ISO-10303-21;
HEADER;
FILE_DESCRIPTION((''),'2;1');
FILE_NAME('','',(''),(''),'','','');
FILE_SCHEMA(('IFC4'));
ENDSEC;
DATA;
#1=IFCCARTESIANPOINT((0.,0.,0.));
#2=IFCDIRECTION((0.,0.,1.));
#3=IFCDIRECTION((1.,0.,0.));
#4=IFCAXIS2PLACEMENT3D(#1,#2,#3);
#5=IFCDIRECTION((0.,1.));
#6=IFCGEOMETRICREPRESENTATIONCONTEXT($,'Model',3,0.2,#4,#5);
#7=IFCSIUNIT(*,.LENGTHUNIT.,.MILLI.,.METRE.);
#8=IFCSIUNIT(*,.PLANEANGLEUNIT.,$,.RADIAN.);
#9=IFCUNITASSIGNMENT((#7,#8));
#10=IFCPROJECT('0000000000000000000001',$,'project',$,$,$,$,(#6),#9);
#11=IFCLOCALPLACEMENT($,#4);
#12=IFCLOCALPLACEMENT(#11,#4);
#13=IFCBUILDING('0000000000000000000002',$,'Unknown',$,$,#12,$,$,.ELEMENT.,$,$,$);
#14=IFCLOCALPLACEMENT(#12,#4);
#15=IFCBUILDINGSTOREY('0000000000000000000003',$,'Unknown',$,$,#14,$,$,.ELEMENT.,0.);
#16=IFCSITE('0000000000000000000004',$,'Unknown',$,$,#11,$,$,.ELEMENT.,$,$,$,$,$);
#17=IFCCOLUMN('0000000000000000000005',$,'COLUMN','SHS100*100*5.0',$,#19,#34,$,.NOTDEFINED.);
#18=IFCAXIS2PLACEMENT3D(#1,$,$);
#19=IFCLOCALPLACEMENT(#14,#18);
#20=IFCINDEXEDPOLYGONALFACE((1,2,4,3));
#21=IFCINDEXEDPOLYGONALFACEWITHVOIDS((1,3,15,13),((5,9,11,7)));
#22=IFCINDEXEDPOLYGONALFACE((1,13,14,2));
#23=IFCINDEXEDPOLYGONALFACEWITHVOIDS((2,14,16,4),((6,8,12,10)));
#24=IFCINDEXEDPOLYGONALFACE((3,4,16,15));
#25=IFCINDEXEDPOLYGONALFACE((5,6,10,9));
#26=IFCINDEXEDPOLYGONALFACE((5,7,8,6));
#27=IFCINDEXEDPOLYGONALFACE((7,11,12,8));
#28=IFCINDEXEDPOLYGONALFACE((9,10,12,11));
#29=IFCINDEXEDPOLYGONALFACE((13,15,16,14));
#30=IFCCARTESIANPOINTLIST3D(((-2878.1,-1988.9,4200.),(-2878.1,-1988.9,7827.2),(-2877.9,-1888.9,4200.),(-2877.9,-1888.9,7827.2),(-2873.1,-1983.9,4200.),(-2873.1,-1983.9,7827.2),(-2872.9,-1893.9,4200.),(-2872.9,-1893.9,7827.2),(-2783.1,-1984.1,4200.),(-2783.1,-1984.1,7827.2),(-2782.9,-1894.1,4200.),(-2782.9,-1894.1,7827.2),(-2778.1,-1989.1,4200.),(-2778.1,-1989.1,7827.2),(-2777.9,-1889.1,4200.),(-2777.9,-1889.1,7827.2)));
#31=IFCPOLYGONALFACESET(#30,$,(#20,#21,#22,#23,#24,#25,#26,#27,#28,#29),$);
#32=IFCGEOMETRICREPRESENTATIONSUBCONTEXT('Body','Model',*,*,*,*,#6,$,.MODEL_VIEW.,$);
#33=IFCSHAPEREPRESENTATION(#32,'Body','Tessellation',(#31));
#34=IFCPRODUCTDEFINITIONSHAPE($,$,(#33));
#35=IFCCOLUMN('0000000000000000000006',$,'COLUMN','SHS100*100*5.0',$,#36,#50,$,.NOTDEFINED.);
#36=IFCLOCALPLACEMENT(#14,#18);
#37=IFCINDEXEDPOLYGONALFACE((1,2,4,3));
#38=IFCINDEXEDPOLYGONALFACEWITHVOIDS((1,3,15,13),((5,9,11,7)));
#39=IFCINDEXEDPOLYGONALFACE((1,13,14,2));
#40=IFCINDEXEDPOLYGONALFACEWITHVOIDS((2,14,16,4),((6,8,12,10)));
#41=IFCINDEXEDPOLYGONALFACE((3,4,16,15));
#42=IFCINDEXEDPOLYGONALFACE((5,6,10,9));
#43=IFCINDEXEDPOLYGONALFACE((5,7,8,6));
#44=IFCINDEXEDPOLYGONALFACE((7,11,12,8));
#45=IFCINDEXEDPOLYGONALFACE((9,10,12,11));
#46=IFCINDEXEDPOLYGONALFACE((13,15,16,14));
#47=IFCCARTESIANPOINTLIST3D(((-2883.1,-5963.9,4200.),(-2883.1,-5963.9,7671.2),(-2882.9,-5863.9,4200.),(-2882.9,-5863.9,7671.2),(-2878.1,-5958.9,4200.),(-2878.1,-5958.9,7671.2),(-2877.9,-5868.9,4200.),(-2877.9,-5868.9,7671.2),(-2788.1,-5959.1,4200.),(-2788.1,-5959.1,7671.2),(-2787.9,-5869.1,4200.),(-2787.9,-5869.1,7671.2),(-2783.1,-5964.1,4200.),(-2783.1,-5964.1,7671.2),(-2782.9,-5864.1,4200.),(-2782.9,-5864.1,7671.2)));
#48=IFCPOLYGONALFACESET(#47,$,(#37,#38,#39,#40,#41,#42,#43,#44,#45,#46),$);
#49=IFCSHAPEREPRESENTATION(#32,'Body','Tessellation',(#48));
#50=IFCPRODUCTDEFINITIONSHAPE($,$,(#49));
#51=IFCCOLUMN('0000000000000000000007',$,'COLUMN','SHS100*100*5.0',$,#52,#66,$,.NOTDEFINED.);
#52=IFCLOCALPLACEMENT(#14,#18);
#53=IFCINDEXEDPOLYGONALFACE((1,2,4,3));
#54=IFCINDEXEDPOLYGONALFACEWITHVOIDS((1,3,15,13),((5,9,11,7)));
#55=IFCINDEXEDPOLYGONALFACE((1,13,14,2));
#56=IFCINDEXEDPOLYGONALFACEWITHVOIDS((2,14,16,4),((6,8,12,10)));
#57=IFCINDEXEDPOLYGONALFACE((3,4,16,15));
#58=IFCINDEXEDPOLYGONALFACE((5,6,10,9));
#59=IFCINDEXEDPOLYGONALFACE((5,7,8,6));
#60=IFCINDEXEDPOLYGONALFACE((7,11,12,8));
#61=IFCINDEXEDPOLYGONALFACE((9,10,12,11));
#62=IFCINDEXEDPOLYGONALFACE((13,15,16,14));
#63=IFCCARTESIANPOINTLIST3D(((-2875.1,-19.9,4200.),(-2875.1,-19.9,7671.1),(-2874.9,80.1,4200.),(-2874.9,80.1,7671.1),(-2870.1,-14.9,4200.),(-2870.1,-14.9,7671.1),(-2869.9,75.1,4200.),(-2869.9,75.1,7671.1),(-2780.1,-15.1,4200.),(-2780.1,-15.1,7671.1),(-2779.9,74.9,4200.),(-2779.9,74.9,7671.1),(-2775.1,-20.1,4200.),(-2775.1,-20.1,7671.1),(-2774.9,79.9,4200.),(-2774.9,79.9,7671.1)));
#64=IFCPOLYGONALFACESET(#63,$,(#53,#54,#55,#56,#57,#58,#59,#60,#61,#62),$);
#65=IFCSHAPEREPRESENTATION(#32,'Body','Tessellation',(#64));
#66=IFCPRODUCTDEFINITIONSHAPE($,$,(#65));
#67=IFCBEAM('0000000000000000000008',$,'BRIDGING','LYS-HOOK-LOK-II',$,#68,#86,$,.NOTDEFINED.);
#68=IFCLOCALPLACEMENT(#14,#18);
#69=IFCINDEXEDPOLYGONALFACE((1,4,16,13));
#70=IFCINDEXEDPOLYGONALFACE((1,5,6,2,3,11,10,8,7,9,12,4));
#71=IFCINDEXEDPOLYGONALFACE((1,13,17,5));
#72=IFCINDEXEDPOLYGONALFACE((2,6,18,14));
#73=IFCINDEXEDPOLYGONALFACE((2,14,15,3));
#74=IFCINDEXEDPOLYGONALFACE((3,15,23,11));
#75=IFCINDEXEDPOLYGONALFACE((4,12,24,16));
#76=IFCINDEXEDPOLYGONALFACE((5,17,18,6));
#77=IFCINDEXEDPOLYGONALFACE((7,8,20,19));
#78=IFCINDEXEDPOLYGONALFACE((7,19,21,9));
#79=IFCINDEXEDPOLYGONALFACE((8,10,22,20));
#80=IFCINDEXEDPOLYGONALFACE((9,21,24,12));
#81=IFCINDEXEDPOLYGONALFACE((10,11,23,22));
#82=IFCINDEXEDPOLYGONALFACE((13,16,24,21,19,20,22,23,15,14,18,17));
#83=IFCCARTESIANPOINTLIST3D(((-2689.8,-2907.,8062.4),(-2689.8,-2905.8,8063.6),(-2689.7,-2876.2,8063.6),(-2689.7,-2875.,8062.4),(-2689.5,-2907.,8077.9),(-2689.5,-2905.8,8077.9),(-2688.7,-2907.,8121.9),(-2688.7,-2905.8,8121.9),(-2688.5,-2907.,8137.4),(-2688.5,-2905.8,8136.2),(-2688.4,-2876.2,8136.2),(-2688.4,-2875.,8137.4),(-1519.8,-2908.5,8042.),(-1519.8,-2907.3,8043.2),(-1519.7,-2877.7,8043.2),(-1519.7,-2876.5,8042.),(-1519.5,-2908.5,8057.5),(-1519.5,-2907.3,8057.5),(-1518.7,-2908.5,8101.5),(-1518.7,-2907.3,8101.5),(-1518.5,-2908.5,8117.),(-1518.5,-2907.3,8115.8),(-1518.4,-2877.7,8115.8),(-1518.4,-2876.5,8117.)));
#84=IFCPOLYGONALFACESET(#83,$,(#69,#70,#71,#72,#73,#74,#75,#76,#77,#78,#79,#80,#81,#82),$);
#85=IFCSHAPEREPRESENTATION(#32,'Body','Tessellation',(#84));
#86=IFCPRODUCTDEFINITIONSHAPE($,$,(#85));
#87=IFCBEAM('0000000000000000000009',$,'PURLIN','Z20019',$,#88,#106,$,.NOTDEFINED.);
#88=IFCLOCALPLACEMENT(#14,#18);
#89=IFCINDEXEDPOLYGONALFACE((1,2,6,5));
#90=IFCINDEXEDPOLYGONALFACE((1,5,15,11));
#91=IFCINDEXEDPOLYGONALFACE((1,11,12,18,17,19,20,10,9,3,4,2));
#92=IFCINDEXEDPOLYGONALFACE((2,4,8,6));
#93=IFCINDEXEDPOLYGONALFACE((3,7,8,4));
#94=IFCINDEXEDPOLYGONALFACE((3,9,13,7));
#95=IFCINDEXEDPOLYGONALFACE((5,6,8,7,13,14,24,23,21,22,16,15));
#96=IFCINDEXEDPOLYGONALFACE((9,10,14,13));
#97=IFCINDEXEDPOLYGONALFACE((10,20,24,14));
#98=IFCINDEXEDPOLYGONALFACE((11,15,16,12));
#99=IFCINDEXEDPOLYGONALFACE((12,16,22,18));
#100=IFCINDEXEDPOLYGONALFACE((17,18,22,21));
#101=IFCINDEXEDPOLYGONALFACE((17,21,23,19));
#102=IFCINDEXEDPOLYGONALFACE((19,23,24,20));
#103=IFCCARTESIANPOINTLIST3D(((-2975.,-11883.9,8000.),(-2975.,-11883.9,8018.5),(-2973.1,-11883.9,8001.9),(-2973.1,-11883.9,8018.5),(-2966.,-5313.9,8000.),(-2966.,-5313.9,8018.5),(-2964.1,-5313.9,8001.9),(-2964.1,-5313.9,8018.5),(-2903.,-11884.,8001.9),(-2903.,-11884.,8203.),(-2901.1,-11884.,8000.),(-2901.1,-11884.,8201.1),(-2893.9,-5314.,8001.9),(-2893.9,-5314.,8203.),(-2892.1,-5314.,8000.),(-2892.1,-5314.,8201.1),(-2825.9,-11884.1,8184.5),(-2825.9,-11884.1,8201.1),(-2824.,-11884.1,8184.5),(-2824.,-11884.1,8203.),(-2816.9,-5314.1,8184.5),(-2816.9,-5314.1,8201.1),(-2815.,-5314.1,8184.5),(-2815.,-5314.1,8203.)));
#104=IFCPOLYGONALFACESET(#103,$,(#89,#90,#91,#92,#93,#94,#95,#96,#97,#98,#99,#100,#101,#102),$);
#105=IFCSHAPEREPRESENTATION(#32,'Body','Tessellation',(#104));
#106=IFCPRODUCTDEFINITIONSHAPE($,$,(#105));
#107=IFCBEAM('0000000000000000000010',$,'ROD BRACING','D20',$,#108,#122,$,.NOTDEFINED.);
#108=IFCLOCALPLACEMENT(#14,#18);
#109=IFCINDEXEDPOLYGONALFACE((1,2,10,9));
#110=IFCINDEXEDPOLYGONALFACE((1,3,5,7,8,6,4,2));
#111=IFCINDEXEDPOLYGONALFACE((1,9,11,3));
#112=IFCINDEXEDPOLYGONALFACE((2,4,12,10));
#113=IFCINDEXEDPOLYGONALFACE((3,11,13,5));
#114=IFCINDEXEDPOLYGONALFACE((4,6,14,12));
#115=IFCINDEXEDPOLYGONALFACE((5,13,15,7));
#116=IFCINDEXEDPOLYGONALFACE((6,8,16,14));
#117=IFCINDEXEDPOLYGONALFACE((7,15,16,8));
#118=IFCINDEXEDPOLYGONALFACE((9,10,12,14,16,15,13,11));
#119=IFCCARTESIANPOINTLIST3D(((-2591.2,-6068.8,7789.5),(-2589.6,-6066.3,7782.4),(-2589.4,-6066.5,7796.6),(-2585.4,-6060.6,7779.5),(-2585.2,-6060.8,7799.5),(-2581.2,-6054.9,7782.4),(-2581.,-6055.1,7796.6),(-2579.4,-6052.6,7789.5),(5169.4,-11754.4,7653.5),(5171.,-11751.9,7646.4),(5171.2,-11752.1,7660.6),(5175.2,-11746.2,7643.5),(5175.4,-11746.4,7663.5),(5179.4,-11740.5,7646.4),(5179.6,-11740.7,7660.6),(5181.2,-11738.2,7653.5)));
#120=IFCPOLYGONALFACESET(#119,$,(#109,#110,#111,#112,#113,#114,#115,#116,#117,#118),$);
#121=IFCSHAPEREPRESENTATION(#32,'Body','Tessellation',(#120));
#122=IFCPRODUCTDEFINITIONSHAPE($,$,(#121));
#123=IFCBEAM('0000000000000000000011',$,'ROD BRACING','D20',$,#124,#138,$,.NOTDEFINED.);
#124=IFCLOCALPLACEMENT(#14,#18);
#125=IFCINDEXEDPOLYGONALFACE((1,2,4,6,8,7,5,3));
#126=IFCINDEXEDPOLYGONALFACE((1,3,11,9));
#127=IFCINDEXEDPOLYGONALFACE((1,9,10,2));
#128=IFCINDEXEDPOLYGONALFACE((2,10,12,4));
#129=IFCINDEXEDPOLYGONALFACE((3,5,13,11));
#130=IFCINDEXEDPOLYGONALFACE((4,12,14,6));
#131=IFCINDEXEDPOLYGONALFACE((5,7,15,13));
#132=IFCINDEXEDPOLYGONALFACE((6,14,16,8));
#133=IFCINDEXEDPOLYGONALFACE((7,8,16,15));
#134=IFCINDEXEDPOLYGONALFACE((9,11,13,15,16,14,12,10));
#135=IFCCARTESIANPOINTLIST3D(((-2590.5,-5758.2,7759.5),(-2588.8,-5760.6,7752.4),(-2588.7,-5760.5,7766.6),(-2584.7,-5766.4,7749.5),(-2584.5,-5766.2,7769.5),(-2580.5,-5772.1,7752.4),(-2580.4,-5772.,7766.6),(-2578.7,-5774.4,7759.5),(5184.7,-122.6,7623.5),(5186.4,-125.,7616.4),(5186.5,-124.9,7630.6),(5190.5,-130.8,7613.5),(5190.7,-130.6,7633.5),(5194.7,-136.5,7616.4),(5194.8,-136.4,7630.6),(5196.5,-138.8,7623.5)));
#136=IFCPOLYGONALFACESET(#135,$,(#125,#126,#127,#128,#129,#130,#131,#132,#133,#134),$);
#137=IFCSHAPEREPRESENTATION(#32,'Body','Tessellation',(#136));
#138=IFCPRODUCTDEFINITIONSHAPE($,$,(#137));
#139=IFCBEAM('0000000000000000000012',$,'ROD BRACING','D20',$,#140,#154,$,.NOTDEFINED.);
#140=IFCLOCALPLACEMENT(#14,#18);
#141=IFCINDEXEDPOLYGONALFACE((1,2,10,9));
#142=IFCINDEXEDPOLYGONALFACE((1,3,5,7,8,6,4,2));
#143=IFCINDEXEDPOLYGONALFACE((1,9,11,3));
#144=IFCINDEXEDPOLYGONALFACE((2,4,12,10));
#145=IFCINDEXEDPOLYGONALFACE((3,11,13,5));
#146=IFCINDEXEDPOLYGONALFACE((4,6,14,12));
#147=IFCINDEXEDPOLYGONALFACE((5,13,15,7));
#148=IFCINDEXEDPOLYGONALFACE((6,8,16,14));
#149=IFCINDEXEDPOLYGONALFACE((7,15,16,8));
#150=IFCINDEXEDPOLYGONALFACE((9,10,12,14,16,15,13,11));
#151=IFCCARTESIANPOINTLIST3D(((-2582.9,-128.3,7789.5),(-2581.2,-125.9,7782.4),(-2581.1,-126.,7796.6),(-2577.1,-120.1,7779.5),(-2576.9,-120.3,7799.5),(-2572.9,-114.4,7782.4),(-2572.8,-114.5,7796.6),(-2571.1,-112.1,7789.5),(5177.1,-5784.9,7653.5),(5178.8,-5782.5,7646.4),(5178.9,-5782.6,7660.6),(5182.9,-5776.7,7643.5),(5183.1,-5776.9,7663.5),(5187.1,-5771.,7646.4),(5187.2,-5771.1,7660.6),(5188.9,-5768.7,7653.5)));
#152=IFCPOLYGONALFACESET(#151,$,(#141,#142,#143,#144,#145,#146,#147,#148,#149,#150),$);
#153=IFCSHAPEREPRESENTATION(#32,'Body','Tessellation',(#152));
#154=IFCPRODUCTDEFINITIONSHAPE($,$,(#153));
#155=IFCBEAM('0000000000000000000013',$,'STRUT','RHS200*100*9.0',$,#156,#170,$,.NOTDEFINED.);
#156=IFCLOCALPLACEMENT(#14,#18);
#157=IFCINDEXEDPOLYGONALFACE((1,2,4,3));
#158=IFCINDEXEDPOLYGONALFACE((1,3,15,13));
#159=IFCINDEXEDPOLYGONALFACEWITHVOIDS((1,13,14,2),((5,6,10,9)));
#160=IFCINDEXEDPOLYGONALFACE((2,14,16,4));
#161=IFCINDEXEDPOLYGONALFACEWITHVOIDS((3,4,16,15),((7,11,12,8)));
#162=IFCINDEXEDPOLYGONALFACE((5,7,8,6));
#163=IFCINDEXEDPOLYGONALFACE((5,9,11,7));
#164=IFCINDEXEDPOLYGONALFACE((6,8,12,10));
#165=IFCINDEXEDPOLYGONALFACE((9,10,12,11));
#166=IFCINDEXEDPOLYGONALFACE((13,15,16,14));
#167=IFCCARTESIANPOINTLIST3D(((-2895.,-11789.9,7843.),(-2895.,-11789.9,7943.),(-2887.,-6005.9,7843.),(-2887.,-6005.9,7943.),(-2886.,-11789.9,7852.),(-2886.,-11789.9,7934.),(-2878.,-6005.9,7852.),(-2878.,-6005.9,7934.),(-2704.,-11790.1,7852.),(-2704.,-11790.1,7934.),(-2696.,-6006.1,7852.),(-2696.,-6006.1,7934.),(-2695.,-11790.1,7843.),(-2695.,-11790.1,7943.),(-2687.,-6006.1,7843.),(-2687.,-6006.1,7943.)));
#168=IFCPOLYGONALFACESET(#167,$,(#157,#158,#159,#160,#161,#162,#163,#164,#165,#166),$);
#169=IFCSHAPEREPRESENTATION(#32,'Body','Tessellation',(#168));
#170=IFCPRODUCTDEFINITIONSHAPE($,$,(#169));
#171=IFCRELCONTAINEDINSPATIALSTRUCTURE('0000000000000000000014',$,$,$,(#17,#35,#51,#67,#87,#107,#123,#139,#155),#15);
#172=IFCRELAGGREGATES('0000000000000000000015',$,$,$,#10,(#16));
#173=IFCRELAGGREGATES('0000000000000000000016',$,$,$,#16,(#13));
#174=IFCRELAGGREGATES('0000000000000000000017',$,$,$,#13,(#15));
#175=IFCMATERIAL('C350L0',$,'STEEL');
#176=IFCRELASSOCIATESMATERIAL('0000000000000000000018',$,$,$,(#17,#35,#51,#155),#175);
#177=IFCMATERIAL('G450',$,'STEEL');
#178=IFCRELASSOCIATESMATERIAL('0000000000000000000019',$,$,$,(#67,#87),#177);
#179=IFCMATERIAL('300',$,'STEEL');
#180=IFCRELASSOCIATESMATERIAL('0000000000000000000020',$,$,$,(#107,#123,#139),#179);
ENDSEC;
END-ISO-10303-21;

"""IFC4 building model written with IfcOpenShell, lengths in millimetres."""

from ifc_helpers import new_model, si_unit, direction, frame, origin_with_axes, place, context, subcontext, project, spatial, line, indexed_curve, outline, extrude, material, element, save


model = new_model("IFC4")

# Units and contexts
model_context = context("Model", 3, precision=0.2, world=origin_with_axes(), true_north=direction((0.0, 1.0)))
body_context = subcontext(model_context, "Body", "Model", "MODEL_VIEW")
ifc_project = project(units=[si_unit("LENGTHUNIT", "METRE", prefix="MILLI"), si_unit("PLANEANGLEUNIT", "RADIAN")], contexts=[model_context])

# Site, building, storey
site_placement = place(None, origin_with_axes())
site = spatial("IfcSite", under=ifc_project, at=site_placement, Name="Unknown", CompositionType="ELEMENT")
building_placement = place(site_placement, origin_with_axes())
building = spatial("IfcBuilding", under=site, at=building_placement, Name="Unknown", CompositionType="ELEMENT")
storey_placement = place(building_placement, origin_with_axes())
storey = spatial("IfcBuildingStorey", under=building, at=storey_placement, Name="Unknown", CompositionType="ELEMENT", Elevation=0.0)

# Columns
ifc_material_1 = material(Name="C350L0", Category="STEEL")
column_1_placement = place(storey_placement, frame((-2828.0, -1939.0, 4200.0), z_axis=(0.999999, -0.001396, 0.0), x_axis=(0.0, 0.0, 1.0)))
element("IfcColumn", 1, at=column_1_placement, inside=storey, material=ifc_material_1, Name="COLUMN", Description="SHS100*100*5.0", PredefinedType="NOTDEFINED", context=body_context, shape_type="SolidModel", body=[
    extrude(outline(indexed_curve([(-50.0, -50.0), (50.0, -50.0), (50.0, 50.0), (-50.0, 50.0)], segments=[line(1, 2, 3, 4, 1)]), holes=[indexed_curve([(-45.0, -45.0), (-45.0, 45.0), (45.0, 45.0), (45.0, -45.0)], segments=[line(1, 2, 3, 4, 1)])]), frame((0.0, 0.0, 0.0), z_axis=(-1.0, 0.0, 0.0), x_axis=(0.0, 0.0, 1.0)), (0.0, 0.0, -1.0), 3627.2),
])
column_2_placement = place(storey_placement, frame((-2833.0, -5914.0, 4200.0), z_axis=(0.999999, -0.001571, 0.0), x_axis=(0.0, 0.0, 1.0)))
element("IfcColumn", 2, at=column_2_placement, inside=storey, material=ifc_material_1, Name="COLUMN", Description="SHS100*100*5.0", PredefinedType="NOTDEFINED", context=body_context, shape_type="SolidModel", body=[
    extrude(outline(indexed_curve([(-50.0, -50.0), (50.0, -50.0), (50.0, 50.0), (-50.0, 50.0)], segments=[line(1, 2, 3, 4, 1)]), holes=[indexed_curve([(-45.0, -45.0), (-45.0, 45.0), (45.0, 45.0), (45.0, -45.0)], segments=[line(1, 2, 3, 4, 1)])]), frame((0.0, 0.0, 0.0), z_axis=(-1.0, 0.0, 0.0), x_axis=(0.0, 0.0, 1.0)), (0.0, 0.0, -1.0), 3471.2),
])
column_3_placement = place(storey_placement, frame((-2825.0, 30.0, 4200.0), z_axis=(0.999999, -0.001571, 0.0), x_axis=(0.0, 0.0, 1.0)))
element("IfcColumn", 3, at=column_3_placement, inside=storey, material=ifc_material_1, Name="COLUMN", Description="SHS100*100*5.0", PredefinedType="NOTDEFINED", context=body_context, shape_type="SolidModel", body=[
    extrude(outline(indexed_curve([(-50.0, -50.0), (50.0, -50.0), (50.0, 50.0), (-50.0, 50.0)], segments=[line(1, 2, 3, 4, 1)]), holes=[indexed_curve([(-45.0, -45.0), (-45.0, 45.0), (45.0, 45.0), (45.0, -45.0)], segments=[line(1, 2, 3, 4, 1)])]), frame((0.0, 0.0, 0.0), z_axis=(-1.0, 0.0, 0.0), x_axis=(0.0, 0.0, 1.0)), (0.0, 0.0, -1.0), 3471.1),
])

# Beams
ifc_material_2 = material(Name="G450", Category="STEEL")
beam_1_placement = place(storey_placement, frame((-2689.1, -2891.0, 8099.9), z_axis=(-0.001282, -0.999999, 0.0), x_axis=(0.999847, -0.001282, -0.017433)))
element("IfcBeam", 4, at=beam_1_placement, inside=storey, material=ifc_material_2, Name="BRIDGING", Description="LYS-HOOK-LOK-II", PredefinedType="NOTDEFINED", context=body_context, shape_type="SolidModel", body=[
    extrude(outline(indexed_curve([(16.0, -37.5), (16.0, -22.0), (14.8, -22.0), (14.8, -36.3), (-14.8, -36.3), (-14.8, 36.3), (14.8, 36.3), (14.8, 22.0), (16.0, 22.0), (16.0, 37.5), (-16.0, 37.5), (-16.0, -37.5)], segments=[line(1, 2, 3, 4, 5, 6, 7, 8, 9, 10, 11, 12, 1)])), frame((0.0, 0.0, 0.0), z_axis=(-1.0, 0.0, 0.0), x_axis=(0.0, 0.0, 1.0)), (0.0, 0.0, -1.0), 1170.2),
])
beam_2_placement = place(storey_placement, frame((-2893.0, -5314.0, 8101.5), z_axis=(-0.999999, 0.00137, 0.0), x_axis=(-0.00137, -0.999999, 0.0)))
element("IfcBeam", 5, at=beam_2_placement, inside=storey, material=ifc_material_2, Name="PURLIN", Description="Z20019", PredefinedType="NOTDEFINED", context=body_context, shape_type="SolidModel", body=[
    extrude(outline(indexed_curve([(73.0, -101.5), (73.0, -83.0), (71.2, -83.0), (71.2, -99.6), (0.9, -99.6), (0.9, 101.5), (-78.0, 101.5), (-78.0, 83.0), (-76.2, 83.0), (-76.2, 99.6), (-0.9, 99.6), (-0.9, -101.5)], segments=[line(1, 2, 3, 4, 5, 6, 7, 8, 9, 10, 11, 12, 1)])), frame((0.0, 0.0, 0.0), z_axis=(-1.0, 0.0, 0.0), x_axis=(0.0, 0.0, 1.0)), (0.0, 0.0, -1.0), 6570.0),
])
ifc_material_3 = material(Name="300", Category="STEEL")
beam_3_placement = place(storey_placement, frame((-2585.3, -6060.7, 7789.5), z_axis=(0.011403, -0.008354, 0.9999), x_axis=(0.806597, -0.590932, -0.014135)))
element("IfcBeam", 6, at=beam_3_placement, inside=storey, material=ifc_material_3, Name="ROD BRACING", Description="D20", PredefinedType="NOTDEFINED", context=body_context, shape_type="SolidModel", body=[
    extrude(outline(indexed_curve([(10.0, 0.0), (7.1, 7.1), (0.0, 10.0), (-7.1, 7.1), (-10.0, 0.0), (-7.1, -7.1), (0.0, -10.0), (7.1, -7.1)], segments=[line(1, 2, 3, 4, 5, 6, 7, 8, 1)])), frame((0.0, 0.0, 0.0), z_axis=(-1.0, 0.0, 0.0), x_axis=(0.0, 0.0, 1.0)), (0.0, 0.0, -1.0), 9621.4),
])
beam_4_placement = place(storey_placement, frame((-2584.6, -5766.3, 7759.5), z_axis=(0.011466, 0.008311, 0.9999), x_axis=(0.8096, 0.586812, -0.014161)))
element("IfcBeam", 7, at=beam_4_placement, inside=storey, material=ifc_material_3, Name="ROD BRACING", Description="D20", PredefinedType="NOTDEFINED", context=body_context, shape_type="SolidModel", body=[
    extrude(outline(indexed_curve([(10.0, 0.0), (7.1, 7.1), (0.0, 10.0), (-7.1, 7.1), (-10.0, 0.0), (-7.1, -7.1), (0.0, -10.0), (7.1, -7.1)], segments=[line(1, 2, 3, 4, 5, 6, 7, 8, 1)])), frame((0.0, 0.0, 0.0), z_axis=(-1.0, 0.0, 0.0), x_axis=(0.0, 0.0, 1.0)), (0.0, 0.0, -1.0), 9603.8),
])
beam_5_placement = place(storey_placement, frame((-2577.0, -120.2, 7789.5), z_axis=(0.011443, -0.008342, 0.9999), x_axis=(0.808012, -0.588995, -0.014161)))
element("IfcBeam", 8, at=beam_5_placement, inside=storey, material=ifc_material_3, Name="ROD BRACING", Description="D20", PredefinedType="NOTDEFINED", context=body_context, shape_type="SolidModel", body=[
    extrude(outline(indexed_curve([(10.0, 0.0), (7.1, 7.1), (0.0, 10.0), (-7.1, 7.1), (-10.0, 0.0), (-7.1, -7.1), (0.0, -10.0), (7.1, -7.1)], segments=[line(1, 2, 3, 4, 5, 6, 7, 8, 1)])), frame((0.0, 0.0, 0.0), z_axis=(-1.0, 0.0, 0.0), x_axis=(0.0, 0.0, 1.0)), (0.0, 0.0, -1.0), 9603.8),
])
beam_6_placement = place(storey_placement, frame((-2787.0, -6006.0, 7893.0), z_axis=(0.0, 0.0, 1.0), x_axis=(-0.001383, -0.999999, 0.0)))
element("IfcBeam", 9, at=beam_6_placement, inside=storey, material=ifc_material_1, Name="STRUT", Description="RHS200*100*9.0", PredefinedType="NOTDEFINED", context=body_context, shape_type="SolidModel", body=[
    extrude(outline(indexed_curve([(-50.0, -100.0), (50.0, -100.0), (50.0, 100.0), (-50.0, 100.0)], segments=[line(1, 2, 3, 4, 1)]), holes=[indexed_curve([(-41.0, -91.0), (-41.0, 91.0), (41.0, 91.0), (41.0, -91.0)], segments=[line(1, 2, 3, 4, 1)])]), frame((0.0, 0.0, 0.0), z_axis=(-1.0, 0.0, 0.0), x_axis=(0.0, 0.0, 1.0)), (0.0, 0.0, -1.0), 5784.0),
])

save(model, "model.ifc")
